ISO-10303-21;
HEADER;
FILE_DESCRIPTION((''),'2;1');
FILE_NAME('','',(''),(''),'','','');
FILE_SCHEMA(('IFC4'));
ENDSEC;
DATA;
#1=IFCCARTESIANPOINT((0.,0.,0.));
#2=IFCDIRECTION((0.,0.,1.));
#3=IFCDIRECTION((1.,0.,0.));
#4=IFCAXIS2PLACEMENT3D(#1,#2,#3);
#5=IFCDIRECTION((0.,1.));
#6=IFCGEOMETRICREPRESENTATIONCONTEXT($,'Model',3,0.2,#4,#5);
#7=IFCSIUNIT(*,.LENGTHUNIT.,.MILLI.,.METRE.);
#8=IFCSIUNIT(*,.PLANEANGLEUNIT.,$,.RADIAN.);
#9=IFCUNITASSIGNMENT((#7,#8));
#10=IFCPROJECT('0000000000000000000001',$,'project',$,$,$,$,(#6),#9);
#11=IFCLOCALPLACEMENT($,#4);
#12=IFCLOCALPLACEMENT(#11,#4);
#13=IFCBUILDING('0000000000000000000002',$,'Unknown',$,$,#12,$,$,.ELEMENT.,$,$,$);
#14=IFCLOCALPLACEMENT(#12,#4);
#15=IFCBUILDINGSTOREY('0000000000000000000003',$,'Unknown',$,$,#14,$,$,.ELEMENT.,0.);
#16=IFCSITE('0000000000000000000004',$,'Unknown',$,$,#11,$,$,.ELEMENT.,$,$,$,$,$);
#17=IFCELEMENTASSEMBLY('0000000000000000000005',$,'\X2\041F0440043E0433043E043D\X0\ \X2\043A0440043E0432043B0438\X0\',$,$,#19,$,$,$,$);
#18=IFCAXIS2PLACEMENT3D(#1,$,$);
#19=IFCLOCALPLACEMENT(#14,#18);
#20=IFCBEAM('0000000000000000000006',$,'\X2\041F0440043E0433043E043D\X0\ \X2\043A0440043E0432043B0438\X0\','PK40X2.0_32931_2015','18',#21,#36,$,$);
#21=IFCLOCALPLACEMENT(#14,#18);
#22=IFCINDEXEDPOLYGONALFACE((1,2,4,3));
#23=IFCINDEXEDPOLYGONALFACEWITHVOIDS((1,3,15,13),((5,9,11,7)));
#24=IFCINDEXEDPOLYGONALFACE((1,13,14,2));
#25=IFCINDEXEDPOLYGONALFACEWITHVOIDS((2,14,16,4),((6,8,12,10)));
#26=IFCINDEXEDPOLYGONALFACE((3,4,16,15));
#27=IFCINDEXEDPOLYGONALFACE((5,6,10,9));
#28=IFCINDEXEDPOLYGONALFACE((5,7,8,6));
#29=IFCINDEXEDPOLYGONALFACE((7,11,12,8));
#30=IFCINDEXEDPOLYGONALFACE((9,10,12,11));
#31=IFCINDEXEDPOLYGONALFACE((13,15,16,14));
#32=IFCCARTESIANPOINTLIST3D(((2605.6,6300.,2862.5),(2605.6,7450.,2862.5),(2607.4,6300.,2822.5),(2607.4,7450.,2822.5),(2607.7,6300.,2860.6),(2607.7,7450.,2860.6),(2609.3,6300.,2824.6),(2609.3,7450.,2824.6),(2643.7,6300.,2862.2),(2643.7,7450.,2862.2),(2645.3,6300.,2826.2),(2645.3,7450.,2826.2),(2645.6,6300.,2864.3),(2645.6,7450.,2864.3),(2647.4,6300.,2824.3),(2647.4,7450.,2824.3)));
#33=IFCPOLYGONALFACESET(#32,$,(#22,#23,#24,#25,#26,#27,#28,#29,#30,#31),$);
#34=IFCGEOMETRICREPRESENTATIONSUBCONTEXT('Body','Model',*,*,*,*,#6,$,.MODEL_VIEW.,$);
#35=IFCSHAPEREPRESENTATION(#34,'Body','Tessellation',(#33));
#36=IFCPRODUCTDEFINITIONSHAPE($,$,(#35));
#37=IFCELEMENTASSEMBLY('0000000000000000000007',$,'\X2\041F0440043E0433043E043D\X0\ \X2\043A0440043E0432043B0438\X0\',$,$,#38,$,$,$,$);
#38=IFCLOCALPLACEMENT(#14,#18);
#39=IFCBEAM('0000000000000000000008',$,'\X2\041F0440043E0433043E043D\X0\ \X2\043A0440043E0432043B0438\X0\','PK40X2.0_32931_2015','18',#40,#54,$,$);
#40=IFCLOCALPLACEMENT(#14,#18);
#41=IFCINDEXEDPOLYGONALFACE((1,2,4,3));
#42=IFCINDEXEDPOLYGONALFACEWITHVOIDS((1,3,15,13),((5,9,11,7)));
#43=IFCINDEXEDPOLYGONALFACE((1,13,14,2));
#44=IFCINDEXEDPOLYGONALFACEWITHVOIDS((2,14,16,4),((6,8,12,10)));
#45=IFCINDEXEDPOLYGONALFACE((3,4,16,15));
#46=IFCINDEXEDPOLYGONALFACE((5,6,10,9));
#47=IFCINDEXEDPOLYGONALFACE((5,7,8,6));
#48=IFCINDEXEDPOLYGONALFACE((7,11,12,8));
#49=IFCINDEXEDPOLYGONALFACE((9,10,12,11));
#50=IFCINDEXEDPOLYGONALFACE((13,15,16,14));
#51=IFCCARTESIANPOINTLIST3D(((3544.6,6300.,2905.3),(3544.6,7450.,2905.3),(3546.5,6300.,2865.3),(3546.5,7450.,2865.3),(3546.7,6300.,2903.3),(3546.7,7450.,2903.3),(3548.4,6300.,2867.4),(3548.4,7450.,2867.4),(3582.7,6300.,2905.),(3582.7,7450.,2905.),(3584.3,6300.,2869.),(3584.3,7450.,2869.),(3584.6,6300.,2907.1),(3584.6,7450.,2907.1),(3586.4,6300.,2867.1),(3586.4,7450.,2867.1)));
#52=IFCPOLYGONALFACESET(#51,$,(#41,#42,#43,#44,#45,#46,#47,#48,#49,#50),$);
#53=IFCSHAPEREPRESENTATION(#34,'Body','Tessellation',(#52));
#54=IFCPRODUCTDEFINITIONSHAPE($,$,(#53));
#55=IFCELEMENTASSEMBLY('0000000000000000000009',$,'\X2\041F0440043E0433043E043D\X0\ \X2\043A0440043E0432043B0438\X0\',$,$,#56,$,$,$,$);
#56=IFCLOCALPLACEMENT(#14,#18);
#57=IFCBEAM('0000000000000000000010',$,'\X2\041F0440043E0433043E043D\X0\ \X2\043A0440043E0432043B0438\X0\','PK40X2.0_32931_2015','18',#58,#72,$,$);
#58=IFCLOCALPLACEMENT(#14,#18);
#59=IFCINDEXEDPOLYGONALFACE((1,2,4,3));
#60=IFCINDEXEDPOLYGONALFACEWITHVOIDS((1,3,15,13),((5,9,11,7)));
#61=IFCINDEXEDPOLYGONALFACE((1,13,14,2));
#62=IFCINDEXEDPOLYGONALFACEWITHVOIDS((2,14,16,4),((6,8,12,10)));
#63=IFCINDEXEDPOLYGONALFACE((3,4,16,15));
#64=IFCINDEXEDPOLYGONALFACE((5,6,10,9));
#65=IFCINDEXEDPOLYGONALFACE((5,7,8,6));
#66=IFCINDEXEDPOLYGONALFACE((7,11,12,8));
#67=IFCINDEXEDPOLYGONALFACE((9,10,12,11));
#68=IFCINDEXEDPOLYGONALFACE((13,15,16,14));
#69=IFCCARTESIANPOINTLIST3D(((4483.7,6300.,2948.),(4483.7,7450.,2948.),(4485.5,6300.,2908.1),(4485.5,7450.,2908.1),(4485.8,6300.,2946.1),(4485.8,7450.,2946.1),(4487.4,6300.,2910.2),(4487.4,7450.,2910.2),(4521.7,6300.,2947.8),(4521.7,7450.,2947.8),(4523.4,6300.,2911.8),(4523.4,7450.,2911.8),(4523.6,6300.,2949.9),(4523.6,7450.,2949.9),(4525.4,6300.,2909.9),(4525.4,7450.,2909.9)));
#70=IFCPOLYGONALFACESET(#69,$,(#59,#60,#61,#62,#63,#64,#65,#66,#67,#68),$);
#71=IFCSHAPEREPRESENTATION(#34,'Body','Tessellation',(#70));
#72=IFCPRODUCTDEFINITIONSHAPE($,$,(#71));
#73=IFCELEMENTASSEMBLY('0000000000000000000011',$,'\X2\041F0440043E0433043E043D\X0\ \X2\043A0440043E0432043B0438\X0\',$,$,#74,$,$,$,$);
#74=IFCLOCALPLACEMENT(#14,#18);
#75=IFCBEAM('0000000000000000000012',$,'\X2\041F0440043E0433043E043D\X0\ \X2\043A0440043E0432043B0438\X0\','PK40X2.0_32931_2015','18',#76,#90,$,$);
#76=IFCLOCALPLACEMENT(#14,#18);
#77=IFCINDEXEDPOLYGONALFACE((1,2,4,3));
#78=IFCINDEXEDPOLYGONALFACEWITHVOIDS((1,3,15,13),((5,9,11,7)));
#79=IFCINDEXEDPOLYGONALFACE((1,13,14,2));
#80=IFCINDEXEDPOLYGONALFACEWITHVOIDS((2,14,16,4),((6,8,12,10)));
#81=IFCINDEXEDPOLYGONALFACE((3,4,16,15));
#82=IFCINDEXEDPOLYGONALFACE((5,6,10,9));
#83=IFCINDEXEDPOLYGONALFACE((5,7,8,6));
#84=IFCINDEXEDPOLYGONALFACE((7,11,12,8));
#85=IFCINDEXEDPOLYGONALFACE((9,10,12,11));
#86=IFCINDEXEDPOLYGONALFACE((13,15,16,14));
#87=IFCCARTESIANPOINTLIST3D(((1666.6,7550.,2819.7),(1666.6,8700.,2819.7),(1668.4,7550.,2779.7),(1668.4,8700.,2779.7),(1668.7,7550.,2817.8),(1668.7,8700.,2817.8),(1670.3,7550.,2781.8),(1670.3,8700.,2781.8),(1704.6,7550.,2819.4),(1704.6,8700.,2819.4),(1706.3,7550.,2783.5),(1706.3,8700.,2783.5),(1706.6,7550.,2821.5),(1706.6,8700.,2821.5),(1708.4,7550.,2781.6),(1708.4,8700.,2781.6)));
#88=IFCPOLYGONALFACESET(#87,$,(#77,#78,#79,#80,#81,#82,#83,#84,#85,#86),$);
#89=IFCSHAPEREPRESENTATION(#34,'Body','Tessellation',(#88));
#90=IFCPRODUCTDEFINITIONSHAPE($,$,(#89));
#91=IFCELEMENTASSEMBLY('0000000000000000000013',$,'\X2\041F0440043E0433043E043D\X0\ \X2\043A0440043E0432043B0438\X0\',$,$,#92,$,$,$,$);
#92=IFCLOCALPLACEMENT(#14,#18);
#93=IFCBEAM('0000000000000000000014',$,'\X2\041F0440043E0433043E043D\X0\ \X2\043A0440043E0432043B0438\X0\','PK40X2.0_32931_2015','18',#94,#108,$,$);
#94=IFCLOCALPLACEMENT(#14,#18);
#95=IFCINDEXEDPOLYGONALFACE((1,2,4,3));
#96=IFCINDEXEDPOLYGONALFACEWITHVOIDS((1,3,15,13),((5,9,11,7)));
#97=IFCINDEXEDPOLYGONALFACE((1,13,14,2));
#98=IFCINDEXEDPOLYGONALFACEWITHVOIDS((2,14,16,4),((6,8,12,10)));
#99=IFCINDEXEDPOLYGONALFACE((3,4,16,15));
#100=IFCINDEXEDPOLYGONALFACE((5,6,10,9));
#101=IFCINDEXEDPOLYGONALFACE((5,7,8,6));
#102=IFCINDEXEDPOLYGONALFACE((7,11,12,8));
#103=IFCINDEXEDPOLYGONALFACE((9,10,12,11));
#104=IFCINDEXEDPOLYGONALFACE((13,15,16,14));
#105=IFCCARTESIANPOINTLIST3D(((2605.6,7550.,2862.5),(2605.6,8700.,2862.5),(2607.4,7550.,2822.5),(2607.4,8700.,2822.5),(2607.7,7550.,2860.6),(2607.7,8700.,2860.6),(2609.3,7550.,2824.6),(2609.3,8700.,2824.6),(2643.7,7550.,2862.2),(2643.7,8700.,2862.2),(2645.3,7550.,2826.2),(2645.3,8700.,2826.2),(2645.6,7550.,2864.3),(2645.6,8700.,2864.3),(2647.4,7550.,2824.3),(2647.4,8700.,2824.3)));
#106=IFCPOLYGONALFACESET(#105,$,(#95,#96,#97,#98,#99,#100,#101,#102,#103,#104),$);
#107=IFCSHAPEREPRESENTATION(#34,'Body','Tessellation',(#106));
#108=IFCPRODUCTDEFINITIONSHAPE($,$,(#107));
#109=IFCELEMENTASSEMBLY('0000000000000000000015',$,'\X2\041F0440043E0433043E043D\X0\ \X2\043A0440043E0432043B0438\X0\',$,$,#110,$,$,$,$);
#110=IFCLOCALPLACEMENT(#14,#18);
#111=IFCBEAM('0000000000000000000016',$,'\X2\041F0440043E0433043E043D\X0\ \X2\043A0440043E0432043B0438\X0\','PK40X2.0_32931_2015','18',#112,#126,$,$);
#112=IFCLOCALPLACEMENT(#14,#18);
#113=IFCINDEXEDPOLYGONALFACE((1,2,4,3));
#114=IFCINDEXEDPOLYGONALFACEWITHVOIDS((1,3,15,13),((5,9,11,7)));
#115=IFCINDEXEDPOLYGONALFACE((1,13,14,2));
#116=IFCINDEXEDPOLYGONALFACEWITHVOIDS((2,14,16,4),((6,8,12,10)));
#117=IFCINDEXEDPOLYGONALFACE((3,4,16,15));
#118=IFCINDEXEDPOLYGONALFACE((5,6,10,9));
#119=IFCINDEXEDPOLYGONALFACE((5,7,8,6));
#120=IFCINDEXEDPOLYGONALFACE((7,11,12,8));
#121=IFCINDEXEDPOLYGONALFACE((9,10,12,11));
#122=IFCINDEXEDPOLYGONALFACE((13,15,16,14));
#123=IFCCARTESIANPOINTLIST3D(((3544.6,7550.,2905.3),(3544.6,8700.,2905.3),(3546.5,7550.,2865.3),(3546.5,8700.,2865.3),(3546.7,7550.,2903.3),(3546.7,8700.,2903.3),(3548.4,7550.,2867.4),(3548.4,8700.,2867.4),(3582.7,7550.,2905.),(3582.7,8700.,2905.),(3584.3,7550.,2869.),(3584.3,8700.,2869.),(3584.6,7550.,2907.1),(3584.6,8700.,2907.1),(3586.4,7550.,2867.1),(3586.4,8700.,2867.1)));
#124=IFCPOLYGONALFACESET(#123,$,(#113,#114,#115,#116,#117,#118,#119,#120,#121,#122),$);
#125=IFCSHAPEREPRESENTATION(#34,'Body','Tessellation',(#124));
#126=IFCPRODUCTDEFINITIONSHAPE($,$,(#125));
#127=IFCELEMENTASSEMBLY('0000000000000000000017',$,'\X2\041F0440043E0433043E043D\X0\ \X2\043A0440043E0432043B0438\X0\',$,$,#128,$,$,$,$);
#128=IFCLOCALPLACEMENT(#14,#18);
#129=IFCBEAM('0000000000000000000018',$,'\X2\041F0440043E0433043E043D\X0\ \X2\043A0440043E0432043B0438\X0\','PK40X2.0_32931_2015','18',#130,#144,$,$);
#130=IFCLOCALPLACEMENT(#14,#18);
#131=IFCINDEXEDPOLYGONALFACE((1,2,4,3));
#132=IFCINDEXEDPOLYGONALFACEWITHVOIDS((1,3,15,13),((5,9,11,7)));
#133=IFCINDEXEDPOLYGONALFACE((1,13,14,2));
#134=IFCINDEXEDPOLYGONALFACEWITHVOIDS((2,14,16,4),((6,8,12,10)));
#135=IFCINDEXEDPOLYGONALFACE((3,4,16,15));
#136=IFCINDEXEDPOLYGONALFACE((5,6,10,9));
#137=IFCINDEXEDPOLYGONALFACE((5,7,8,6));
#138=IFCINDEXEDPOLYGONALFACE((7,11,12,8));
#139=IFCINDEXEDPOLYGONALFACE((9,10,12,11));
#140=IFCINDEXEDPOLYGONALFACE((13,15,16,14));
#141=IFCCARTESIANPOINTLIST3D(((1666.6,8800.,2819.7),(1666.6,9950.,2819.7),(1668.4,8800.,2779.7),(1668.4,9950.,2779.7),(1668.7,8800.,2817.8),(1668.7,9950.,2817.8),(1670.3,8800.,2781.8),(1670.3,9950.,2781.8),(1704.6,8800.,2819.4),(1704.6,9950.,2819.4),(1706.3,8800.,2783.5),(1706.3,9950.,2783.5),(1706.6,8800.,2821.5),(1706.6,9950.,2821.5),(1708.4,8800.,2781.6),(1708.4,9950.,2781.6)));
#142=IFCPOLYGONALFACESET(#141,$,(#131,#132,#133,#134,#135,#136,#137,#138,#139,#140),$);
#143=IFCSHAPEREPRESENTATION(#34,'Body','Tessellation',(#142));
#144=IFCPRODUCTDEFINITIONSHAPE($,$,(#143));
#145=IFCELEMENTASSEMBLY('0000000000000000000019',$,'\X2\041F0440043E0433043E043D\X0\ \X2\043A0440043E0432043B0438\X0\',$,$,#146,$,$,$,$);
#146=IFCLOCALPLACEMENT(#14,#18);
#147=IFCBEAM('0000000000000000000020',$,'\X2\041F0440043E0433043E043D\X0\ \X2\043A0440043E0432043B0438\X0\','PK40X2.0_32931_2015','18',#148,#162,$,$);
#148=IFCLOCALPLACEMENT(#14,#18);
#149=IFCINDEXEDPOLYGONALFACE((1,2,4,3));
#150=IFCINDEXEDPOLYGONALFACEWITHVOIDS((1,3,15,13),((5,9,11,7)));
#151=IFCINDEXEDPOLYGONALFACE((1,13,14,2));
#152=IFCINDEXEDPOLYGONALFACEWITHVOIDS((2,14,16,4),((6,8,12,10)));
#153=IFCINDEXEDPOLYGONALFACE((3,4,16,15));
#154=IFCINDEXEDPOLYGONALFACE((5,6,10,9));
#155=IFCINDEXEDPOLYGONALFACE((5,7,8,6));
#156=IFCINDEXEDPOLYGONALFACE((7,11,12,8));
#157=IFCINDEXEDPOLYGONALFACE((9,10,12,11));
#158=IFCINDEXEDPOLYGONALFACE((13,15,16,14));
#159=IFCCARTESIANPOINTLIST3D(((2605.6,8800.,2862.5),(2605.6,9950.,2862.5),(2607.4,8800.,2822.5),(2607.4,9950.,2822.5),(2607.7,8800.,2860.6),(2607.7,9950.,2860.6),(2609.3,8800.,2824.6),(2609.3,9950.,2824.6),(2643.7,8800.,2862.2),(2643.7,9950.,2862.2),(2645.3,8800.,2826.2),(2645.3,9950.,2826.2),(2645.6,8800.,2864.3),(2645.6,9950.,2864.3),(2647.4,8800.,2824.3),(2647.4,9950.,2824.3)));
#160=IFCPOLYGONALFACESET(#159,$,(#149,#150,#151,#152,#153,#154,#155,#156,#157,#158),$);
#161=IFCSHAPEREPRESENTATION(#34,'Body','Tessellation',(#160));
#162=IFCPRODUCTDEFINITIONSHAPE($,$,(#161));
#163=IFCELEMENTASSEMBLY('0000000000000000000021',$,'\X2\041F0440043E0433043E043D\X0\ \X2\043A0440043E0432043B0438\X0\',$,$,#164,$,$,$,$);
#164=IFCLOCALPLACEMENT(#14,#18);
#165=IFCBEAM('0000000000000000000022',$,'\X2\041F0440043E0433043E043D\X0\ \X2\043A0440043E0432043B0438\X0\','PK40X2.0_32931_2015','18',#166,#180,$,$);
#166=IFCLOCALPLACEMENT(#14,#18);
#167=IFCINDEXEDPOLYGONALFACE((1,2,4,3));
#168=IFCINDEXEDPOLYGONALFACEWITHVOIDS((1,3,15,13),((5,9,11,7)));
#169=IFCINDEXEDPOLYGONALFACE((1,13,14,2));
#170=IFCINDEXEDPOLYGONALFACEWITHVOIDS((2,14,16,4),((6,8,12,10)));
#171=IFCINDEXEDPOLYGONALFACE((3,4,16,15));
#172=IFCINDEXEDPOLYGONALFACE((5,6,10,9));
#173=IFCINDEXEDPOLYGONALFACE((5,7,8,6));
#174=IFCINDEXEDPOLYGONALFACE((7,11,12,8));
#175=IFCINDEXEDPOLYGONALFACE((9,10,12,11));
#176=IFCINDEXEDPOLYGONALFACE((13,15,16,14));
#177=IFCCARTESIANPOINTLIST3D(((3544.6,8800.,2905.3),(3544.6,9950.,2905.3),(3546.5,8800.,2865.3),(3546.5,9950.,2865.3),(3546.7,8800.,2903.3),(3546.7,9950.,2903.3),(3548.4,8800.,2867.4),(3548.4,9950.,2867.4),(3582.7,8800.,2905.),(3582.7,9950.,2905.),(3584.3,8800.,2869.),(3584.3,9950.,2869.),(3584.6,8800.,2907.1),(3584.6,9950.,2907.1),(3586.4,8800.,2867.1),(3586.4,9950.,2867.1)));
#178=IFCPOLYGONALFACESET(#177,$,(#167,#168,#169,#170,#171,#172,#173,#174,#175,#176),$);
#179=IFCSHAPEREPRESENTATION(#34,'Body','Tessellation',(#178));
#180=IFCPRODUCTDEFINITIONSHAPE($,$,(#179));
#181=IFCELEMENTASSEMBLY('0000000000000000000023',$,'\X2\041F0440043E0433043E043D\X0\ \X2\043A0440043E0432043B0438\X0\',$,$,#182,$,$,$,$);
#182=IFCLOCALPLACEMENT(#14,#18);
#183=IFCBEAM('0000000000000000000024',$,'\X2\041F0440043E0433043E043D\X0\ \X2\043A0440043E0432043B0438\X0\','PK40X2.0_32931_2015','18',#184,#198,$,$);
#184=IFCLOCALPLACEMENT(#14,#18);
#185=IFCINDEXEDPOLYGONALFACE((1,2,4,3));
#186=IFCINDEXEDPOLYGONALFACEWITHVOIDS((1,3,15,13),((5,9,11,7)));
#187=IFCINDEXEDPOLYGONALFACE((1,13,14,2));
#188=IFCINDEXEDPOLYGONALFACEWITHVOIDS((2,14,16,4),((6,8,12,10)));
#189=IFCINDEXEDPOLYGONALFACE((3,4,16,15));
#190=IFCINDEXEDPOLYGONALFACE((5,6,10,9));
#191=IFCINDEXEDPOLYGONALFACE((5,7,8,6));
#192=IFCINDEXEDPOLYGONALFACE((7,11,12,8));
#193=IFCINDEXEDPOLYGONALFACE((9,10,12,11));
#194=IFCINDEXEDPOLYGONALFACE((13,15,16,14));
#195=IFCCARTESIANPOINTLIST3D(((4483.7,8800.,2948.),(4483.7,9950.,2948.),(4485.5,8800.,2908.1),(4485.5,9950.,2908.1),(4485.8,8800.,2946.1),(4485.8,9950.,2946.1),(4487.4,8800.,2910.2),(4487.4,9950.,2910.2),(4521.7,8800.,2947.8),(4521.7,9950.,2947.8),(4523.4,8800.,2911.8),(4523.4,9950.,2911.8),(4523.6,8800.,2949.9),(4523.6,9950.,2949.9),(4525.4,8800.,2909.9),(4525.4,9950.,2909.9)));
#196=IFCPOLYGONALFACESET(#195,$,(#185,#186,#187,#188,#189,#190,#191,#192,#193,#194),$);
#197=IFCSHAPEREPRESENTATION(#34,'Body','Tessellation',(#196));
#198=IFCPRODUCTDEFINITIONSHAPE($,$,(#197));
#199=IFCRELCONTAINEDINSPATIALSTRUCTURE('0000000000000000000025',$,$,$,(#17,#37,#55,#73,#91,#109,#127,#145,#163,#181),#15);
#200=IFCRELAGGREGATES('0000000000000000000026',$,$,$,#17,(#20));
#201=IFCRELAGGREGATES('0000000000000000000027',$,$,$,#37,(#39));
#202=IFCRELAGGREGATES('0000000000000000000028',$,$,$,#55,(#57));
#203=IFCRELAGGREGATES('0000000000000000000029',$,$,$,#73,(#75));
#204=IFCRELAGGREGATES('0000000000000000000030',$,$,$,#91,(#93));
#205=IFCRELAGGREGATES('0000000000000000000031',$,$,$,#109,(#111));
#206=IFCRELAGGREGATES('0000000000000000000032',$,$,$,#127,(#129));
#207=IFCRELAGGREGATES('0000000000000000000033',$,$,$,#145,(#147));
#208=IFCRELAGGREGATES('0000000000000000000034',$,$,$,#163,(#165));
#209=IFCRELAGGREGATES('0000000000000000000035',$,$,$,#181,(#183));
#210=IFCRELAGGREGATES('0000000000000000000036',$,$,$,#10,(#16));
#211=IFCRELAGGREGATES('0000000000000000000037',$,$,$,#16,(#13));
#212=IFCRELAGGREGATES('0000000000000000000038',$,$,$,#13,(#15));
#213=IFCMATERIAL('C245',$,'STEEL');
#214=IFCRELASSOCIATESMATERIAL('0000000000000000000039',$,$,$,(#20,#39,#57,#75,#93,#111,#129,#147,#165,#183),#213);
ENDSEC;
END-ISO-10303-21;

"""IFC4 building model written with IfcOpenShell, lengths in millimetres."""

from ifc_helpers import new_model, si_unit, direction, frame, origin_with_axes, place, context, subcontext, project, spatial, line, indexed_curve, outline, extrude, material, element, aggregate, save


model = new_model("IFC4")

# Units and contexts
model_context = context("Model", 3, precision=0.2, world=origin_with_axes(), true_north=direction((0.0, 1.0)))
body_context = subcontext(model_context, "Body", "Model", "MODEL_VIEW")
ifc_project = project(units=[si_unit("LENGTHUNIT", "METRE", prefix="MILLI"), si_unit("PLANEANGLEUNIT", "RADIAN")], contexts=[model_context])

# Site, building, storey
site_placement = place(None, origin_with_axes())
site = spatial("IfcSite", under=ifc_project, at=site_placement, Name="Unknown", CompositionType="ELEMENT")
building_placement = place(site_placement, origin_with_axes())
building = spatial("IfcBuilding", under=site, at=building_placement, Name="Unknown", CompositionType="ELEMENT")
storey_placement = place(building_placement, origin_with_axes())
storey = spatial("IfcBuildingStorey", under=building, at=storey_placement, Name="Unknown", CompositionType="ELEMENT", Elevation=0.0)

# Shared definitions
ifc_material_1 = material(Name="C245", Category="STEEL")

# Element assemblies, beams
assembly_1_placement = place(storey_placement, frame((2626.5, 7450.0, 2843.4), z_axis=(-0.998964, 0.0, -0.045508), x_axis=(0.0, -1.0, 0.0)))
assembly_1 = element("IfcElementAssembly", 1, at=assembly_1_placement, inside=storey, Name="Прогон кровли")
beam_1_placement = place(assembly_1_placement, origin_with_axes())
beam_1 = element("IfcBeam", 2, at=beam_1_placement, material=ifc_material_1, Name="Прогон кровли", Description="PK40X2.0_32931_2015", ObjectType="18", context=body_context, shape_type="SolidModel", body=[
    extrude(outline(indexed_curve([(-20.0, -20.0), (20.0, -20.0), (20.0, 20.0), (-20.0, 20.0)], segments=[line(1, 2, 3, 4, 1)]), holes=[indexed_curve([(-18.0, -18.0), (-18.0, 18.0), (18.0, 18.0), (18.0, -18.0)], segments=[line(1, 2, 3, 4, 1)])]), frame((0.0, 0.0, 0.0), z_axis=(-1.0, 0.0, 0.0), x_axis=(0.0, 0.0, 1.0)), (0.0, 0.0, -1.0), 1150.0),
])
aggregate(assembly_1, [beam_1])
assembly_2_placement = place(storey_placement, frame((3565.5, 7450.0, 2886.2), z_axis=(-0.998964, 0.0, -0.045508), x_axis=(0.0, -1.0, 0.0)))
assembly_2 = element("IfcElementAssembly", 3, at=assembly_2_placement, inside=storey, Name="Прогон кровли")
beam_2_placement = place(assembly_2_placement, origin_with_axes())
beam_2 = element("IfcBeam", 4, at=beam_2_placement, material=ifc_material_1, Name="Прогон кровли", Description="PK40X2.0_32931_2015", ObjectType="18", context=body_context, shape_type="SolidModel", body=[
    extrude(outline(indexed_curve([(-20.0, -20.0), (20.0, -20.0), (20.0, 20.0), (-20.0, 20.0)], segments=[line(1, 2, 3, 4, 1)]), holes=[indexed_curve([(-18.0, -18.0), (-18.0, 18.0), (18.0, 18.0), (18.0, -18.0)], segments=[line(1, 2, 3, 4, 1)])]), frame((0.0, 0.0, 0.0), z_axis=(-1.0, 0.0, 0.0), x_axis=(0.0, 0.0, 1.0)), (0.0, 0.0, -1.0), 1150.0),
])
aggregate(assembly_2, [beam_2])
assembly_3_placement = place(storey_placement, frame((4504.6, 7450.0, 2929.0), z_axis=(-0.998964, 0.0, -0.045508), x_axis=(0.0, -1.0, 0.0)))
assembly_3 = element("IfcElementAssembly", 5, at=assembly_3_placement, inside=storey, Name="Прогон кровли")
beam_3_placement = place(assembly_3_placement, origin_with_axes())
beam_3 = element("IfcBeam", 6, at=beam_3_placement, material=ifc_material_1, Name="Прогон кровли", Description="PK40X2.0_32931_2015", ObjectType="18", context=body_context, shape_type="SolidModel", body=[
    extrude(outline(indexed_curve([(-20.0, -20.0), (20.0, -20.0), (20.0, 20.0), (-20.0, 20.0)], segments=[line(1, 2, 3, 4, 1)]), holes=[indexed_curve([(-18.0, -18.0), (-18.0, 18.0), (18.0, 18.0), (18.0, -18.0)], segments=[line(1, 2, 3, 4, 1)])]), frame((0.0, 0.0, 0.0), z_axis=(-1.0, 0.0, 0.0), x_axis=(0.0, 0.0, 1.0)), (0.0, 0.0, -1.0), 1150.0),
])
aggregate(assembly_3, [beam_3])
assembly_4_placement = place(storey_placement, frame((1687.5, 8700.0, 2800.6), z_axis=(-0.998964, 0.0, -0.045508), x_axis=(0.0, -1.0, 0.0)))
assembly_4 = element("IfcElementAssembly", 7, at=assembly_4_placement, inside=storey, Name="Прогон кровли")
beam_4_placement = place(assembly_4_placement, origin_with_axes())
beam_4 = element("IfcBeam", 8, at=beam_4_placement, material=ifc_material_1, Name="Прогон кровли", Description="PK40X2.0_32931_2015", ObjectType="18", context=body_context, shape_type="SolidModel", body=[
    extrude(outline(indexed_curve([(-20.0, -20.0), (20.0, -20.0), (20.0, 20.0), (-20.0, 20.0)], segments=[line(1, 2, 3, 4, 1)]), holes=[indexed_curve([(-18.0, -18.0), (-18.0, 18.0), (18.0, 18.0), (18.0, -18.0)], segments=[line(1, 2, 3, 4, 1)])]), frame((0.0, 0.0, 0.0), z_axis=(-1.0, 0.0, 0.0), x_axis=(0.0, 0.0, 1.0)), (0.0, 0.0, -1.0), 1150.0),
])
aggregate(assembly_4, [beam_4])
assembly_5_placement = place(storey_placement, frame((2626.5, 8700.0, 2843.4), z_axis=(-0.998964, 0.0, -0.045508), x_axis=(0.0, -1.0, 0.0)))
assembly_5 = element("IfcElementAssembly", 9, at=assembly_5_placement, inside=storey, Name="Прогон кровли")
beam_5_placement = place(assembly_5_placement, origin_with_axes())
beam_5 = element("IfcBeam", 10, at=beam_5_placement, material=ifc_material_1, Name="Прогон кровли", Description="PK40X2.0_32931_2015", ObjectType="18", context=body_context, shape_type="SolidModel", body=[
    extrude(outline(indexed_curve([(-20.0, -20.0), (20.0, -20.0), (20.0, 20.0), (-20.0, 20.0)], segments=[line(1, 2, 3, 4, 1)]), holes=[indexed_curve([(-18.0, -18.0), (-18.0, 18.0), (18.0, 18.0), (18.0, -18.0)], segments=[line(1, 2, 3, 4, 1)])]), frame((0.0, 0.0, 0.0), z_axis=(-1.0, 0.0, 0.0), x_axis=(0.0, 0.0, 1.0)), (0.0, 0.0, -1.0), 1150.0),
])
aggregate(assembly_5, [beam_5])
assembly_6_placement = place(storey_placement, frame((3565.5, 8700.0, 2886.2), z_axis=(-0.998964, 0.0, -0.045508), x_axis=(0.0, -1.0, 0.0)))
assembly_6 = element("IfcElementAssembly", 11, at=assembly_6_placement, inside=storey, Name="Прогон кровли")
beam_6_placement = place(assembly_6_placement, origin_with_axes())
beam_6 = element("IfcBeam", 12, at=beam_6_placement, material=ifc_material_1, Name="Прогон кровли", Description="PK40X2.0_32931_2015", ObjectType="18", context=body_context, shape_type="SolidModel", body=[
    extrude(outline(indexed_curve([(-20.0, -20.0), (20.0, -20.0), (20.0, 20.0), (-20.0, 20.0)], segments=[line(1, 2, 3, 4, 1)]), holes=[indexed_curve([(-18.0, -18.0), (-18.0, 18.0), (18.0, 18.0), (18.0, -18.0)], segments=[line(1, 2, 3, 4, 1)])]), frame((0.0, 0.0, 0.0), z_axis=(-1.0, 0.0, 0.0), x_axis=(0.0, 0.0, 1.0)), (0.0, 0.0, -1.0), 1150.0),
])
aggregate(assembly_6, [beam_6])
assembly_7_placement = place(storey_placement, frame((1687.5, 9950.0, 2800.6), z_axis=(-0.998964, 0.0, -0.045508), x_axis=(0.0, -1.0, 0.0)))
assembly_7 = element("IfcElementAssembly", 13, at=assembly_7_placement, inside=storey, Name="Прогон кровли")
beam_7_placement = place(assembly_7_placement, origin_with_axes())
beam_7 = element("IfcBeam", 14, at=beam_7_placement, material=ifc_material_1, Name="Прогон кровли", Description="PK40X2.0_32931_2015", ObjectType="18", context=body_context, shape_type="SolidModel", body=[
    extrude(outline(indexed_curve([(-20.0, -20.0), (20.0, -20.0), (20.0, 20.0), (-20.0, 20.0)], segments=[line(1, 2, 3, 4, 1)]), holes=[indexed_curve([(-18.0, -18.0), (-18.0, 18.0), (18.0, 18.0), (18.0, -18.0)], segments=[line(1, 2, 3, 4, 1)])]), frame((0.0, 0.0, 0.0), z_axis=(-1.0, 0.0, 0.0), x_axis=(0.0, 0.0, 1.0)), (0.0, 0.0, -1.0), 1150.0),
])
aggregate(assembly_7, [beam_7])
assembly_8_placement = place(storey_placement, frame((2626.5, 9950.0, 2843.4), z_axis=(-0.998964, 0.0, -0.045508), x_axis=(0.0, -1.0, 0.0)))
assembly_8 = element("IfcElementAssembly", 15, at=assembly_8_placement, inside=storey, Name="Прогон кровли")
beam_8_placement = place(assembly_8_placement, origin_with_axes())
beam_8 = element("IfcBeam", 16, at=beam_8_placement, material=ifc_material_1, Name="Прогон кровли", Description="PK40X2.0_32931_2015", ObjectType="18", context=body_context, shape_type="SolidModel", body=[
    extrude(outline(indexed_curve([(-20.0, -20.0), (20.0, -20.0), (20.0, 20.0), (-20.0, 20.0)], segments=[line(1, 2, 3, 4, 1)]), holes=[indexed_curve([(-18.0, -18.0), (-18.0, 18.0), (18.0, 18.0), (18.0, -18.0)], segments=[line(1, 2, 3, 4, 1)])]), frame((0.0, 0.0, 0.0), z_axis=(-1.0, 0.0, 0.0), x_axis=(0.0, 0.0, 1.0)), (0.0, 0.0, -1.0), 1150.0),
])
aggregate(assembly_8, [beam_8])
assembly_9_placement = place(storey_placement, frame((3565.5, 9950.0, 2886.2), z_axis=(-0.998964, 0.0, -0.045508), x_axis=(0.0, -1.0, 0.0)))
assembly_9 = element("IfcElementAssembly", 17, at=assembly_9_placement, inside=storey, Name="Прогон кровли")
beam_9_placement = place(assembly_9_placement, origin_with_axes())
beam_9 = element("IfcBeam", 18, at=beam_9_placement, material=ifc_material_1, Name="Прогон кровли", Description="PK40X2.0_32931_2015", ObjectType="18", context=body_context, shape_type="SolidModel", body=[
    extrude(outline(indexed_curve([(-20.0, -20.0), (20.0, -20.0), (20.0, 20.0), (-20.0, 20.0)], segments=[line(1, 2, 3, 4, 1)]), holes=[indexed_curve([(-18.0, -18.0), (-18.0, 18.0), (18.0, 18.0), (18.0, -18.0)], segments=[line(1, 2, 3, 4, 1)])]), frame((0.0, 0.0, 0.0), z_axis=(-1.0, 0.0, 0.0), x_axis=(0.0, 0.0, 1.0)), (0.0, 0.0, -1.0), 1150.0),
])
aggregate(assembly_9, [beam_9])
assembly_10_placement = place(storey_placement, frame((4504.6, 9950.0, 2929.0), z_axis=(-0.998964, 0.0, -0.045508), x_axis=(0.0, -1.0, 0.0)))
assembly_10 = element("IfcElementAssembly", 19, at=assembly_10_placement, inside=storey, Name="Прогон кровли")
beam_10_placement = place(assembly_10_placement, origin_with_axes())
beam_10 = element("IfcBeam", 20, at=beam_10_placement, material=ifc_material_1, Name="Прогон кровли", Description="PK40X2.0_32931_2015", ObjectType="18", context=body_context, shape_type="SolidModel", body=[
    extrude(outline(indexed_curve([(-20.0, -20.0), (20.0, -20.0), (20.0, 20.0), (-20.0, 20.0)], segments=[line(1, 2, 3, 4, 1)]), holes=[indexed_curve([(-18.0, -18.0), (-18.0, 18.0), (18.0, 18.0), (18.0, -18.0)], segments=[line(1, 2, 3, 4, 1)])]), frame((0.0, 0.0, 0.0), z_axis=(-1.0, 0.0, 0.0), x_axis=(0.0, 0.0, 1.0)), (0.0, 0.0, -1.0), 1150.0),
])
aggregate(assembly_10, [beam_10])

save(model, "model.ifc")
